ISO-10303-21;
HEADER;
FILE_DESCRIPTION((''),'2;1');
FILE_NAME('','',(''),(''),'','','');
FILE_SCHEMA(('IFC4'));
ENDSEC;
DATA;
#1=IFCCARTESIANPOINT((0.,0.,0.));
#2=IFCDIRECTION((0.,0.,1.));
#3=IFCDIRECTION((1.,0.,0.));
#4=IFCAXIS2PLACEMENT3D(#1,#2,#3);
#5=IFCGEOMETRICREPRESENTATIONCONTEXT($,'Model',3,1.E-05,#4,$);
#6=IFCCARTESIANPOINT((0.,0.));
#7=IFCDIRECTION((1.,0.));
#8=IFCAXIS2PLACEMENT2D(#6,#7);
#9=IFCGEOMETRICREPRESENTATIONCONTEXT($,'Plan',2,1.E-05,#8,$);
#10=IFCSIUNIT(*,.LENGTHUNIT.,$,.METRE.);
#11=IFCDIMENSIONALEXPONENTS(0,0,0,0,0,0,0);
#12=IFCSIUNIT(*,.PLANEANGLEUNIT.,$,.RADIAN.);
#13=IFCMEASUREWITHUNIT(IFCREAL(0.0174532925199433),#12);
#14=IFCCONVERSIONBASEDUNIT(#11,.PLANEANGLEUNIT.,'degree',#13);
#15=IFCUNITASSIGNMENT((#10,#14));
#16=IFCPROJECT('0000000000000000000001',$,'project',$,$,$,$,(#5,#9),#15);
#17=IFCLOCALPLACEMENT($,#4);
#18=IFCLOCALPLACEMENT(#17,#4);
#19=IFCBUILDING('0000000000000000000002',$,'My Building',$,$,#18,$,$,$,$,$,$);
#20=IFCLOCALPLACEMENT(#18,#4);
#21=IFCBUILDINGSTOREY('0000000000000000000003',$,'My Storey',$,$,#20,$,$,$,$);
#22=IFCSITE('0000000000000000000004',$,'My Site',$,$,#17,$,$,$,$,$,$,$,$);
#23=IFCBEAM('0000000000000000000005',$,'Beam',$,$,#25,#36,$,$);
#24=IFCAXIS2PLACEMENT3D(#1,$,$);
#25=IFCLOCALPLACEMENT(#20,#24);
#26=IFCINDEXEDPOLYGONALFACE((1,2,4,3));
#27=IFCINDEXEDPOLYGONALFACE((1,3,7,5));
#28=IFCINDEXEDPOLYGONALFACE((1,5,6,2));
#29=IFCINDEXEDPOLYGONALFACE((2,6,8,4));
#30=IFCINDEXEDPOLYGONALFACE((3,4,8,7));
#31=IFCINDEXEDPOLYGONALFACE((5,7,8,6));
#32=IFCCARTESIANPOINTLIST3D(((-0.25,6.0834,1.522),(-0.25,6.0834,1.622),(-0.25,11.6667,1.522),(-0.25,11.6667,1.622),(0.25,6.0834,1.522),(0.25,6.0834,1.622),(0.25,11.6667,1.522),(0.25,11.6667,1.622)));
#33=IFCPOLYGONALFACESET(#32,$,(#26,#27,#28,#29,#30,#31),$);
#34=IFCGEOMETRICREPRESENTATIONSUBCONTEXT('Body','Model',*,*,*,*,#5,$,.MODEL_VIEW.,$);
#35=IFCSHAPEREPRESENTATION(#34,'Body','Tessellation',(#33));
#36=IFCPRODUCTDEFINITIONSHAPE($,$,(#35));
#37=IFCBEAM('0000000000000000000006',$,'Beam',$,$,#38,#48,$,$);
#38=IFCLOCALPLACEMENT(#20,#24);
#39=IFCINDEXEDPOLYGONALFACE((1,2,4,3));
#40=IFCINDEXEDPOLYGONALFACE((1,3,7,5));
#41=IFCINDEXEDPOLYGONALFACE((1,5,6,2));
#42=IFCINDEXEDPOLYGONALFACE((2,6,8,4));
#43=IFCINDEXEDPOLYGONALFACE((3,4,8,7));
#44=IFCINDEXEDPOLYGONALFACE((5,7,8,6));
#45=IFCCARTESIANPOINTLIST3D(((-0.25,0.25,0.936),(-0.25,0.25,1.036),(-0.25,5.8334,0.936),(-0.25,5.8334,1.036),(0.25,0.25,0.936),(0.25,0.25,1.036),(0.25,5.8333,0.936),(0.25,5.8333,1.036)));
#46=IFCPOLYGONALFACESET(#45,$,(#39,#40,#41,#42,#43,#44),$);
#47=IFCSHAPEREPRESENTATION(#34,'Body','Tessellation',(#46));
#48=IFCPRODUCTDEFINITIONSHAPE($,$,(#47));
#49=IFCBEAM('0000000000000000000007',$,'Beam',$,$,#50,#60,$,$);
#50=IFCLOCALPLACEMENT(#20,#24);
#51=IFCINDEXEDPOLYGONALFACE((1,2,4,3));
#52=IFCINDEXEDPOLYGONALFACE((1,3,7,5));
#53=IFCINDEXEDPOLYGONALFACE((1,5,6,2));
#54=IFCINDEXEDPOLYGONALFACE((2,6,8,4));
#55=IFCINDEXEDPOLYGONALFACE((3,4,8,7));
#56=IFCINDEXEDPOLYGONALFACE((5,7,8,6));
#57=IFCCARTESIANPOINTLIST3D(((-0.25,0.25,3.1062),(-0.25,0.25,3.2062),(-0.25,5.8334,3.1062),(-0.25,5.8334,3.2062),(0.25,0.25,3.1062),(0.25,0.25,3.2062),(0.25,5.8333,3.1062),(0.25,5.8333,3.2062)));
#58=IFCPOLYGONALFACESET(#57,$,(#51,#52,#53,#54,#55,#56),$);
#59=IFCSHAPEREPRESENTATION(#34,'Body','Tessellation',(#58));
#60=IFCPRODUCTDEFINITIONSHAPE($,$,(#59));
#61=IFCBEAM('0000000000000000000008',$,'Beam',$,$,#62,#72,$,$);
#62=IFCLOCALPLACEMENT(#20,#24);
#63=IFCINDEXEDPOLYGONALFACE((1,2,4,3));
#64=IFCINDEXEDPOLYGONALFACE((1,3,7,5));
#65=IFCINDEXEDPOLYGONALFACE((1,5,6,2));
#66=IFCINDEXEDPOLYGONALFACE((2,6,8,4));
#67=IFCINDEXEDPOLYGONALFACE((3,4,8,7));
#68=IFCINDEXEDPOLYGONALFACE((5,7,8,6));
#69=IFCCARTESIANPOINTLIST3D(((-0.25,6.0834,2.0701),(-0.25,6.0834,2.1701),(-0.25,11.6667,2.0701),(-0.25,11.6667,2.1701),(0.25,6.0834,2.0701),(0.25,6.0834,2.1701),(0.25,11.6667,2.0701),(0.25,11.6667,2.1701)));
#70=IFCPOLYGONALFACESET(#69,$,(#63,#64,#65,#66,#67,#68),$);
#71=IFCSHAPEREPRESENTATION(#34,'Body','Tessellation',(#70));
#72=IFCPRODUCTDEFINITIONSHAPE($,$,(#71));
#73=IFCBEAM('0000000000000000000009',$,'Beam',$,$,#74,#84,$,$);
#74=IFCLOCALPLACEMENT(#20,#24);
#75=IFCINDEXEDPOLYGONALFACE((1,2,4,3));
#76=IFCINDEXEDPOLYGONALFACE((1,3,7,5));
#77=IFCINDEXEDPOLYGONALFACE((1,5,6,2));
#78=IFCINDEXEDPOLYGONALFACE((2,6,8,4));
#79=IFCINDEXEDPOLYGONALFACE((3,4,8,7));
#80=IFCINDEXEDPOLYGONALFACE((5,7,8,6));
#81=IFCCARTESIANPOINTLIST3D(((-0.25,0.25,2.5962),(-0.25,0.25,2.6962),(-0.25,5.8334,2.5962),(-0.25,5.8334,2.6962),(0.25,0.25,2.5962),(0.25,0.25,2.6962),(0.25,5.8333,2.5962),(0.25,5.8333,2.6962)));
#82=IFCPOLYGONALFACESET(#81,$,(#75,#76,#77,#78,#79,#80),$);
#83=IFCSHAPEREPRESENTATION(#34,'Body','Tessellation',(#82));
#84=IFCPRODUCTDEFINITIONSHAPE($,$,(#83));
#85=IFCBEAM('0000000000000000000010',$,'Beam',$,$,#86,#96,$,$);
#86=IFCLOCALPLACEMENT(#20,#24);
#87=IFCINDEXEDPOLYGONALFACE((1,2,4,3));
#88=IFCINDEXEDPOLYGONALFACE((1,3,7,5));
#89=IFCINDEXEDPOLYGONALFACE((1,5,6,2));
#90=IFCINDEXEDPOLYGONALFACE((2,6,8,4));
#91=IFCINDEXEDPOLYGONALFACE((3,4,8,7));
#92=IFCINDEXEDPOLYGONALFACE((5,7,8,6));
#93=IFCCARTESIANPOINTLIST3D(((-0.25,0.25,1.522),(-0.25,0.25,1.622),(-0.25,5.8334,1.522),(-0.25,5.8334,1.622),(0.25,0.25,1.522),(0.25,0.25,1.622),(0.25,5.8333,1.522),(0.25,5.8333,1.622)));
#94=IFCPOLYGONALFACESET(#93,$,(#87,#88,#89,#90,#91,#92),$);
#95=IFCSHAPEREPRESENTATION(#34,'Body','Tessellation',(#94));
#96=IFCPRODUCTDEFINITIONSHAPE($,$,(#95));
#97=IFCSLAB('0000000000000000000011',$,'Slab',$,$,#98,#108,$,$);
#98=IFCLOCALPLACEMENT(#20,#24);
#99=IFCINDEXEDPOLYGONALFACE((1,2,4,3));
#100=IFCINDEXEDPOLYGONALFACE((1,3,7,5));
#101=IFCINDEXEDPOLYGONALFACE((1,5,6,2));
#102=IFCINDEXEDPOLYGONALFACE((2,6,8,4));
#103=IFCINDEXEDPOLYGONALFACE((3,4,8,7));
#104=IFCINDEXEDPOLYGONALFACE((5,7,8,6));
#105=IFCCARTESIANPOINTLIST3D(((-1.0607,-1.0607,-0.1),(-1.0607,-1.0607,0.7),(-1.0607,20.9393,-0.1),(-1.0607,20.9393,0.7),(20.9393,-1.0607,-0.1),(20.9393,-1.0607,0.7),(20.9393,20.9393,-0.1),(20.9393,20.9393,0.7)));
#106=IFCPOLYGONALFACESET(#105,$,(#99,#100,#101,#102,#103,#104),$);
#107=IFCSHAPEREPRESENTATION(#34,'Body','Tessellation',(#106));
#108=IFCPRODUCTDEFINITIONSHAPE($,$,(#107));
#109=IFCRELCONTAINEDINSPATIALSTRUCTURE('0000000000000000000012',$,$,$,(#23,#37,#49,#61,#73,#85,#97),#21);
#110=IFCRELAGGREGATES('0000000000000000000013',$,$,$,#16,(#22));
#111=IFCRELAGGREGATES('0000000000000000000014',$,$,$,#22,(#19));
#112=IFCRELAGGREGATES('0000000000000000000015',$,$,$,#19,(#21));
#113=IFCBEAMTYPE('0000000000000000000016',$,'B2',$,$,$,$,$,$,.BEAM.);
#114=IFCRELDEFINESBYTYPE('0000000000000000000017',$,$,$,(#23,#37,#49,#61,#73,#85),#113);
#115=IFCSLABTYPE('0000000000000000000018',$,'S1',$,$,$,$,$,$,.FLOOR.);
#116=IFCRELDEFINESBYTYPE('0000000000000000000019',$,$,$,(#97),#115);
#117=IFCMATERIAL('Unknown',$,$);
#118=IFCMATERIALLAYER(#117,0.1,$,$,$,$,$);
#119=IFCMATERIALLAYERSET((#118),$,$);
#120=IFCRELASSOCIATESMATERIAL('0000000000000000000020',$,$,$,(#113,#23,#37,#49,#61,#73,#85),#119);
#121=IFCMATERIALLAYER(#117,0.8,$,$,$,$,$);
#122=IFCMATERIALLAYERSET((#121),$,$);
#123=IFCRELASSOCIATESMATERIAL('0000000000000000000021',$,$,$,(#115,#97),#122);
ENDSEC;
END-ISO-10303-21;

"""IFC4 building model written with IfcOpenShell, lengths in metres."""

from ifc_helpers import new_model, entity, si_unit, converted_unit, frame, origin_with_axes, origin_2d_with_axis, place, context, subcontext, project, spatial, indexed_curve, outline, extrude, material, layer, layer_set, layer_usage, type_object, element, save


model = new_model("IFC4")

# Units and contexts
model_context = context("Model", 3, precision=1e-05, world=origin_with_axes())
plan_context = context("Plan", 2, precision=1e-05, world=origin_2d_with_axis())
body_context = subcontext(model_context, "Body", "Model", "MODEL_VIEW")
ifc_project = project(units=[si_unit("LENGTHUNIT", "METRE"), converted_unit("PLANEANGLEUNIT", "degree", entity("IfcReal", 0.0174532925199433), si_unit("PLANEANGLEUNIT", "RADIAN"), dimensions=[0, 0, 0, 0, 0, 0, 0])], contexts=[model_context, plan_context])

# Site, building, storey
site_placement = place(None, origin_with_axes())
site = spatial("IfcSite", under=ifc_project, at=site_placement, Name="My Site")
building_placement = place(site_placement, origin_with_axes())
building = spatial("IfcBuilding", under=site, at=building_placement, Name="My Building")
storey_placement = place(building_placement, origin_with_axes())
storey = spatial("IfcBuildingStorey", under=building, at=storey_placement, Name="My Storey")

# Shared definitions
ifc_material = material(Name="Unknown")

# Beams
ifc_layer_1 = layer(ifc_material, 0.1)
ifc_layer_set_1 = layer_set([ifc_layer_1])
beam_type_1 = type_object("IfcBeamType", Name="B2", PredefinedType="BEAM", material=ifc_layer_set_1)
ifc_layer_usage_1 = layer_usage(ifc_layer_set_1, "AXIS3", "POSITIVE", -0.1)
beam_1_placement = place(storey_placement, frame((-0.25, 6.0834, 1.622), z_axis=(0.0, 0.0, 1.0), x_axis=(0.0, 1.0, 0.0)))
element("IfcBeam", 1, at=beam_1_placement, inside=storey, type_object=beam_type_1, material=ifc_layer_usage_1, Name="Beam", context=body_context, shape_type="SweptSolid", body=[
    extrude(outline(indexed_curve([(0.0, 0.0), (0.0, -0.5), (5.5833, -0.5), (5.5834, 0.0), (0.0, 0.0)])), frame((0.0, 0.0, -0.1), z_axis=(0.0, 0.0, 1.0), x_axis=(1.0, 0.0, 0.0)), (0.0, 0.0, 1.0), 0.1),
])
ifc_layer_usage_2 = layer_usage(ifc_layer_set_1, "AXIS3", "POSITIVE", -0.1)
beam_2_placement = place(storey_placement, frame((-0.25, 0.25, 1.036), z_axis=(0.0, 0.0, 1.0), x_axis=(0.0, 1.0, 0.0)))
element("IfcBeam", 2, at=beam_2_placement, inside=storey, type_object=beam_type_1, material=ifc_layer_usage_2, Name="Beam", context=body_context, shape_type="SweptSolid", body=[
    extrude(outline(indexed_curve([(0.0, 0.0), (0.0, -0.5), (5.5833, -0.5), (5.5834, 0.0), (0.0, 0.0)])), frame((0.0, 0.0, -0.1), z_axis=(0.0, 0.0, 1.0), x_axis=(1.0, 0.0, 0.0)), (0.0, 0.0, 1.0), 0.1),
])
ifc_layer_usage_3 = layer_usage(ifc_layer_set_1, "AXIS3", "POSITIVE", -0.1)
beam_3_placement = place(storey_placement, frame((-0.25, 0.25, 3.2062), z_axis=(0.0, 0.0, 1.0), x_axis=(0.0, 1.0, 0.0)))
element("IfcBeam", 3, at=beam_3_placement, inside=storey, type_object=beam_type_1, material=ifc_layer_usage_3, Name="Beam", context=body_context, shape_type="SweptSolid", body=[
    extrude(outline(indexed_curve([(0.0, 0.0), (0.0, -0.5), (5.5833, -0.5), (5.5834, 0.0), (0.0, 0.0)])), frame((0.0, 0.0, -0.1), z_axis=(0.0, 0.0, 1.0), x_axis=(1.0, 0.0, 0.0)), (0.0, 0.0, 1.0), 0.1),
])
ifc_layer_usage_4 = layer_usage(ifc_layer_set_1, "AXIS3", "POSITIVE", -0.1)
beam_4_placement = place(storey_placement, frame((-0.25, 6.0834, 2.1701), z_axis=(0.0, 0.0, 1.0), x_axis=(0.0, 1.0, 0.0)))
element("IfcBeam", 4, at=beam_4_placement, inside=storey, type_object=beam_type_1, material=ifc_layer_usage_4, Name="Beam", context=body_context, shape_type="SweptSolid", body=[
    extrude(outline(indexed_curve([(0.0, 0.0), (0.0, -0.5), (5.5833, -0.5), (5.5834, 0.0), (0.0, 0.0)])), frame((0.0, 0.0, -0.1), z_axis=(0.0, 0.0, 1.0), x_axis=(1.0, 0.0, 0.0)), (0.0, 0.0, 1.0), 0.1),
])
ifc_layer_usage_5 = layer_usage(ifc_layer_set_1, "AXIS3", "POSITIVE", -0.1)
beam_5_placement = place(storey_placement, frame((-0.25, 0.25, 2.6962), z_axis=(0.0, 0.0, 1.0), x_axis=(0.0, 1.0, 0.0)))
element("IfcBeam", 5, at=beam_5_placement, inside=storey, type_object=beam_type_1, material=ifc_layer_usage_5, Name="Beam", context=body_context, shape_type="SweptSolid", body=[
    extrude(outline(indexed_curve([(0.0, 0.0), (0.0, -0.5), (5.5833, -0.5), (5.5834, 0.0), (0.0, 0.0)])), frame((0.0, 0.0, -0.1), z_axis=(0.0, 0.0, 1.0), x_axis=(1.0, 0.0, 0.0)), (0.0, 0.0, 1.0), 0.1),
])
ifc_layer_usage_6 = layer_usage(ifc_layer_set_1, "AXIS3", "POSITIVE", -0.1)
beam_6_placement = place(storey_placement, frame((-0.25, 0.25, 1.622), z_axis=(0.0, 0.0, 1.0), x_axis=(0.0, 1.0, 0.0)))
element("IfcBeam", 6, at=beam_6_placement, inside=storey, type_object=beam_type_1, material=ifc_layer_usage_6, Name="Beam", context=body_context, shape_type="SweptSolid", body=[
    extrude(outline(indexed_curve([(0.0, 0.0), (0.0, -0.5), (5.5833, -0.5), (5.5834, 0.0), (0.0, 0.0)])), frame((0.0, 0.0, -0.1), z_axis=(0.0, 0.0, 1.0), x_axis=(1.0, 0.0, 0.0)), (0.0, 0.0, 1.0), 0.1),
])

# Slab
ifc_layer_2 = layer(ifc_material, 0.8)
ifc_layer_set_2 = layer_set([ifc_layer_2])
ifc_layer_usage_7 = layer_usage(ifc_layer_set_2, "AXIS3", "POSITIVE", -0.1)
slab_type = type_object("IfcSlabType", Name="S1", PredefinedType="FLOOR", material=ifc_layer_set_2)
slab_placement = place(storey_placement, frame((-1.0607, -1.0607, 0.0), z_axis=(0.0, 0.0, 1.0), x_axis=(1.0, 0.0, 0.0)))
element("IfcSlab", 7, at=slab_placement, inside=storey, type_object=slab_type, material=ifc_layer_usage_7, Name="Slab", context=body_context, shape_type="SweptSolid", body=[
    extrude(outline(indexed_curve([(0.0, 0.0), (22.0, 0.0), (22.0, 22.0), (0.0, 22.0), (0.0, 0.0)])), frame((0.0, 0.0, -0.1), z_axis=(0.0, 0.0, 1.0), x_axis=(1.0, 0.0, 0.0)), (0.0, 0.0, 1.0), 0.8),
])

save(model, "model.ifc")
